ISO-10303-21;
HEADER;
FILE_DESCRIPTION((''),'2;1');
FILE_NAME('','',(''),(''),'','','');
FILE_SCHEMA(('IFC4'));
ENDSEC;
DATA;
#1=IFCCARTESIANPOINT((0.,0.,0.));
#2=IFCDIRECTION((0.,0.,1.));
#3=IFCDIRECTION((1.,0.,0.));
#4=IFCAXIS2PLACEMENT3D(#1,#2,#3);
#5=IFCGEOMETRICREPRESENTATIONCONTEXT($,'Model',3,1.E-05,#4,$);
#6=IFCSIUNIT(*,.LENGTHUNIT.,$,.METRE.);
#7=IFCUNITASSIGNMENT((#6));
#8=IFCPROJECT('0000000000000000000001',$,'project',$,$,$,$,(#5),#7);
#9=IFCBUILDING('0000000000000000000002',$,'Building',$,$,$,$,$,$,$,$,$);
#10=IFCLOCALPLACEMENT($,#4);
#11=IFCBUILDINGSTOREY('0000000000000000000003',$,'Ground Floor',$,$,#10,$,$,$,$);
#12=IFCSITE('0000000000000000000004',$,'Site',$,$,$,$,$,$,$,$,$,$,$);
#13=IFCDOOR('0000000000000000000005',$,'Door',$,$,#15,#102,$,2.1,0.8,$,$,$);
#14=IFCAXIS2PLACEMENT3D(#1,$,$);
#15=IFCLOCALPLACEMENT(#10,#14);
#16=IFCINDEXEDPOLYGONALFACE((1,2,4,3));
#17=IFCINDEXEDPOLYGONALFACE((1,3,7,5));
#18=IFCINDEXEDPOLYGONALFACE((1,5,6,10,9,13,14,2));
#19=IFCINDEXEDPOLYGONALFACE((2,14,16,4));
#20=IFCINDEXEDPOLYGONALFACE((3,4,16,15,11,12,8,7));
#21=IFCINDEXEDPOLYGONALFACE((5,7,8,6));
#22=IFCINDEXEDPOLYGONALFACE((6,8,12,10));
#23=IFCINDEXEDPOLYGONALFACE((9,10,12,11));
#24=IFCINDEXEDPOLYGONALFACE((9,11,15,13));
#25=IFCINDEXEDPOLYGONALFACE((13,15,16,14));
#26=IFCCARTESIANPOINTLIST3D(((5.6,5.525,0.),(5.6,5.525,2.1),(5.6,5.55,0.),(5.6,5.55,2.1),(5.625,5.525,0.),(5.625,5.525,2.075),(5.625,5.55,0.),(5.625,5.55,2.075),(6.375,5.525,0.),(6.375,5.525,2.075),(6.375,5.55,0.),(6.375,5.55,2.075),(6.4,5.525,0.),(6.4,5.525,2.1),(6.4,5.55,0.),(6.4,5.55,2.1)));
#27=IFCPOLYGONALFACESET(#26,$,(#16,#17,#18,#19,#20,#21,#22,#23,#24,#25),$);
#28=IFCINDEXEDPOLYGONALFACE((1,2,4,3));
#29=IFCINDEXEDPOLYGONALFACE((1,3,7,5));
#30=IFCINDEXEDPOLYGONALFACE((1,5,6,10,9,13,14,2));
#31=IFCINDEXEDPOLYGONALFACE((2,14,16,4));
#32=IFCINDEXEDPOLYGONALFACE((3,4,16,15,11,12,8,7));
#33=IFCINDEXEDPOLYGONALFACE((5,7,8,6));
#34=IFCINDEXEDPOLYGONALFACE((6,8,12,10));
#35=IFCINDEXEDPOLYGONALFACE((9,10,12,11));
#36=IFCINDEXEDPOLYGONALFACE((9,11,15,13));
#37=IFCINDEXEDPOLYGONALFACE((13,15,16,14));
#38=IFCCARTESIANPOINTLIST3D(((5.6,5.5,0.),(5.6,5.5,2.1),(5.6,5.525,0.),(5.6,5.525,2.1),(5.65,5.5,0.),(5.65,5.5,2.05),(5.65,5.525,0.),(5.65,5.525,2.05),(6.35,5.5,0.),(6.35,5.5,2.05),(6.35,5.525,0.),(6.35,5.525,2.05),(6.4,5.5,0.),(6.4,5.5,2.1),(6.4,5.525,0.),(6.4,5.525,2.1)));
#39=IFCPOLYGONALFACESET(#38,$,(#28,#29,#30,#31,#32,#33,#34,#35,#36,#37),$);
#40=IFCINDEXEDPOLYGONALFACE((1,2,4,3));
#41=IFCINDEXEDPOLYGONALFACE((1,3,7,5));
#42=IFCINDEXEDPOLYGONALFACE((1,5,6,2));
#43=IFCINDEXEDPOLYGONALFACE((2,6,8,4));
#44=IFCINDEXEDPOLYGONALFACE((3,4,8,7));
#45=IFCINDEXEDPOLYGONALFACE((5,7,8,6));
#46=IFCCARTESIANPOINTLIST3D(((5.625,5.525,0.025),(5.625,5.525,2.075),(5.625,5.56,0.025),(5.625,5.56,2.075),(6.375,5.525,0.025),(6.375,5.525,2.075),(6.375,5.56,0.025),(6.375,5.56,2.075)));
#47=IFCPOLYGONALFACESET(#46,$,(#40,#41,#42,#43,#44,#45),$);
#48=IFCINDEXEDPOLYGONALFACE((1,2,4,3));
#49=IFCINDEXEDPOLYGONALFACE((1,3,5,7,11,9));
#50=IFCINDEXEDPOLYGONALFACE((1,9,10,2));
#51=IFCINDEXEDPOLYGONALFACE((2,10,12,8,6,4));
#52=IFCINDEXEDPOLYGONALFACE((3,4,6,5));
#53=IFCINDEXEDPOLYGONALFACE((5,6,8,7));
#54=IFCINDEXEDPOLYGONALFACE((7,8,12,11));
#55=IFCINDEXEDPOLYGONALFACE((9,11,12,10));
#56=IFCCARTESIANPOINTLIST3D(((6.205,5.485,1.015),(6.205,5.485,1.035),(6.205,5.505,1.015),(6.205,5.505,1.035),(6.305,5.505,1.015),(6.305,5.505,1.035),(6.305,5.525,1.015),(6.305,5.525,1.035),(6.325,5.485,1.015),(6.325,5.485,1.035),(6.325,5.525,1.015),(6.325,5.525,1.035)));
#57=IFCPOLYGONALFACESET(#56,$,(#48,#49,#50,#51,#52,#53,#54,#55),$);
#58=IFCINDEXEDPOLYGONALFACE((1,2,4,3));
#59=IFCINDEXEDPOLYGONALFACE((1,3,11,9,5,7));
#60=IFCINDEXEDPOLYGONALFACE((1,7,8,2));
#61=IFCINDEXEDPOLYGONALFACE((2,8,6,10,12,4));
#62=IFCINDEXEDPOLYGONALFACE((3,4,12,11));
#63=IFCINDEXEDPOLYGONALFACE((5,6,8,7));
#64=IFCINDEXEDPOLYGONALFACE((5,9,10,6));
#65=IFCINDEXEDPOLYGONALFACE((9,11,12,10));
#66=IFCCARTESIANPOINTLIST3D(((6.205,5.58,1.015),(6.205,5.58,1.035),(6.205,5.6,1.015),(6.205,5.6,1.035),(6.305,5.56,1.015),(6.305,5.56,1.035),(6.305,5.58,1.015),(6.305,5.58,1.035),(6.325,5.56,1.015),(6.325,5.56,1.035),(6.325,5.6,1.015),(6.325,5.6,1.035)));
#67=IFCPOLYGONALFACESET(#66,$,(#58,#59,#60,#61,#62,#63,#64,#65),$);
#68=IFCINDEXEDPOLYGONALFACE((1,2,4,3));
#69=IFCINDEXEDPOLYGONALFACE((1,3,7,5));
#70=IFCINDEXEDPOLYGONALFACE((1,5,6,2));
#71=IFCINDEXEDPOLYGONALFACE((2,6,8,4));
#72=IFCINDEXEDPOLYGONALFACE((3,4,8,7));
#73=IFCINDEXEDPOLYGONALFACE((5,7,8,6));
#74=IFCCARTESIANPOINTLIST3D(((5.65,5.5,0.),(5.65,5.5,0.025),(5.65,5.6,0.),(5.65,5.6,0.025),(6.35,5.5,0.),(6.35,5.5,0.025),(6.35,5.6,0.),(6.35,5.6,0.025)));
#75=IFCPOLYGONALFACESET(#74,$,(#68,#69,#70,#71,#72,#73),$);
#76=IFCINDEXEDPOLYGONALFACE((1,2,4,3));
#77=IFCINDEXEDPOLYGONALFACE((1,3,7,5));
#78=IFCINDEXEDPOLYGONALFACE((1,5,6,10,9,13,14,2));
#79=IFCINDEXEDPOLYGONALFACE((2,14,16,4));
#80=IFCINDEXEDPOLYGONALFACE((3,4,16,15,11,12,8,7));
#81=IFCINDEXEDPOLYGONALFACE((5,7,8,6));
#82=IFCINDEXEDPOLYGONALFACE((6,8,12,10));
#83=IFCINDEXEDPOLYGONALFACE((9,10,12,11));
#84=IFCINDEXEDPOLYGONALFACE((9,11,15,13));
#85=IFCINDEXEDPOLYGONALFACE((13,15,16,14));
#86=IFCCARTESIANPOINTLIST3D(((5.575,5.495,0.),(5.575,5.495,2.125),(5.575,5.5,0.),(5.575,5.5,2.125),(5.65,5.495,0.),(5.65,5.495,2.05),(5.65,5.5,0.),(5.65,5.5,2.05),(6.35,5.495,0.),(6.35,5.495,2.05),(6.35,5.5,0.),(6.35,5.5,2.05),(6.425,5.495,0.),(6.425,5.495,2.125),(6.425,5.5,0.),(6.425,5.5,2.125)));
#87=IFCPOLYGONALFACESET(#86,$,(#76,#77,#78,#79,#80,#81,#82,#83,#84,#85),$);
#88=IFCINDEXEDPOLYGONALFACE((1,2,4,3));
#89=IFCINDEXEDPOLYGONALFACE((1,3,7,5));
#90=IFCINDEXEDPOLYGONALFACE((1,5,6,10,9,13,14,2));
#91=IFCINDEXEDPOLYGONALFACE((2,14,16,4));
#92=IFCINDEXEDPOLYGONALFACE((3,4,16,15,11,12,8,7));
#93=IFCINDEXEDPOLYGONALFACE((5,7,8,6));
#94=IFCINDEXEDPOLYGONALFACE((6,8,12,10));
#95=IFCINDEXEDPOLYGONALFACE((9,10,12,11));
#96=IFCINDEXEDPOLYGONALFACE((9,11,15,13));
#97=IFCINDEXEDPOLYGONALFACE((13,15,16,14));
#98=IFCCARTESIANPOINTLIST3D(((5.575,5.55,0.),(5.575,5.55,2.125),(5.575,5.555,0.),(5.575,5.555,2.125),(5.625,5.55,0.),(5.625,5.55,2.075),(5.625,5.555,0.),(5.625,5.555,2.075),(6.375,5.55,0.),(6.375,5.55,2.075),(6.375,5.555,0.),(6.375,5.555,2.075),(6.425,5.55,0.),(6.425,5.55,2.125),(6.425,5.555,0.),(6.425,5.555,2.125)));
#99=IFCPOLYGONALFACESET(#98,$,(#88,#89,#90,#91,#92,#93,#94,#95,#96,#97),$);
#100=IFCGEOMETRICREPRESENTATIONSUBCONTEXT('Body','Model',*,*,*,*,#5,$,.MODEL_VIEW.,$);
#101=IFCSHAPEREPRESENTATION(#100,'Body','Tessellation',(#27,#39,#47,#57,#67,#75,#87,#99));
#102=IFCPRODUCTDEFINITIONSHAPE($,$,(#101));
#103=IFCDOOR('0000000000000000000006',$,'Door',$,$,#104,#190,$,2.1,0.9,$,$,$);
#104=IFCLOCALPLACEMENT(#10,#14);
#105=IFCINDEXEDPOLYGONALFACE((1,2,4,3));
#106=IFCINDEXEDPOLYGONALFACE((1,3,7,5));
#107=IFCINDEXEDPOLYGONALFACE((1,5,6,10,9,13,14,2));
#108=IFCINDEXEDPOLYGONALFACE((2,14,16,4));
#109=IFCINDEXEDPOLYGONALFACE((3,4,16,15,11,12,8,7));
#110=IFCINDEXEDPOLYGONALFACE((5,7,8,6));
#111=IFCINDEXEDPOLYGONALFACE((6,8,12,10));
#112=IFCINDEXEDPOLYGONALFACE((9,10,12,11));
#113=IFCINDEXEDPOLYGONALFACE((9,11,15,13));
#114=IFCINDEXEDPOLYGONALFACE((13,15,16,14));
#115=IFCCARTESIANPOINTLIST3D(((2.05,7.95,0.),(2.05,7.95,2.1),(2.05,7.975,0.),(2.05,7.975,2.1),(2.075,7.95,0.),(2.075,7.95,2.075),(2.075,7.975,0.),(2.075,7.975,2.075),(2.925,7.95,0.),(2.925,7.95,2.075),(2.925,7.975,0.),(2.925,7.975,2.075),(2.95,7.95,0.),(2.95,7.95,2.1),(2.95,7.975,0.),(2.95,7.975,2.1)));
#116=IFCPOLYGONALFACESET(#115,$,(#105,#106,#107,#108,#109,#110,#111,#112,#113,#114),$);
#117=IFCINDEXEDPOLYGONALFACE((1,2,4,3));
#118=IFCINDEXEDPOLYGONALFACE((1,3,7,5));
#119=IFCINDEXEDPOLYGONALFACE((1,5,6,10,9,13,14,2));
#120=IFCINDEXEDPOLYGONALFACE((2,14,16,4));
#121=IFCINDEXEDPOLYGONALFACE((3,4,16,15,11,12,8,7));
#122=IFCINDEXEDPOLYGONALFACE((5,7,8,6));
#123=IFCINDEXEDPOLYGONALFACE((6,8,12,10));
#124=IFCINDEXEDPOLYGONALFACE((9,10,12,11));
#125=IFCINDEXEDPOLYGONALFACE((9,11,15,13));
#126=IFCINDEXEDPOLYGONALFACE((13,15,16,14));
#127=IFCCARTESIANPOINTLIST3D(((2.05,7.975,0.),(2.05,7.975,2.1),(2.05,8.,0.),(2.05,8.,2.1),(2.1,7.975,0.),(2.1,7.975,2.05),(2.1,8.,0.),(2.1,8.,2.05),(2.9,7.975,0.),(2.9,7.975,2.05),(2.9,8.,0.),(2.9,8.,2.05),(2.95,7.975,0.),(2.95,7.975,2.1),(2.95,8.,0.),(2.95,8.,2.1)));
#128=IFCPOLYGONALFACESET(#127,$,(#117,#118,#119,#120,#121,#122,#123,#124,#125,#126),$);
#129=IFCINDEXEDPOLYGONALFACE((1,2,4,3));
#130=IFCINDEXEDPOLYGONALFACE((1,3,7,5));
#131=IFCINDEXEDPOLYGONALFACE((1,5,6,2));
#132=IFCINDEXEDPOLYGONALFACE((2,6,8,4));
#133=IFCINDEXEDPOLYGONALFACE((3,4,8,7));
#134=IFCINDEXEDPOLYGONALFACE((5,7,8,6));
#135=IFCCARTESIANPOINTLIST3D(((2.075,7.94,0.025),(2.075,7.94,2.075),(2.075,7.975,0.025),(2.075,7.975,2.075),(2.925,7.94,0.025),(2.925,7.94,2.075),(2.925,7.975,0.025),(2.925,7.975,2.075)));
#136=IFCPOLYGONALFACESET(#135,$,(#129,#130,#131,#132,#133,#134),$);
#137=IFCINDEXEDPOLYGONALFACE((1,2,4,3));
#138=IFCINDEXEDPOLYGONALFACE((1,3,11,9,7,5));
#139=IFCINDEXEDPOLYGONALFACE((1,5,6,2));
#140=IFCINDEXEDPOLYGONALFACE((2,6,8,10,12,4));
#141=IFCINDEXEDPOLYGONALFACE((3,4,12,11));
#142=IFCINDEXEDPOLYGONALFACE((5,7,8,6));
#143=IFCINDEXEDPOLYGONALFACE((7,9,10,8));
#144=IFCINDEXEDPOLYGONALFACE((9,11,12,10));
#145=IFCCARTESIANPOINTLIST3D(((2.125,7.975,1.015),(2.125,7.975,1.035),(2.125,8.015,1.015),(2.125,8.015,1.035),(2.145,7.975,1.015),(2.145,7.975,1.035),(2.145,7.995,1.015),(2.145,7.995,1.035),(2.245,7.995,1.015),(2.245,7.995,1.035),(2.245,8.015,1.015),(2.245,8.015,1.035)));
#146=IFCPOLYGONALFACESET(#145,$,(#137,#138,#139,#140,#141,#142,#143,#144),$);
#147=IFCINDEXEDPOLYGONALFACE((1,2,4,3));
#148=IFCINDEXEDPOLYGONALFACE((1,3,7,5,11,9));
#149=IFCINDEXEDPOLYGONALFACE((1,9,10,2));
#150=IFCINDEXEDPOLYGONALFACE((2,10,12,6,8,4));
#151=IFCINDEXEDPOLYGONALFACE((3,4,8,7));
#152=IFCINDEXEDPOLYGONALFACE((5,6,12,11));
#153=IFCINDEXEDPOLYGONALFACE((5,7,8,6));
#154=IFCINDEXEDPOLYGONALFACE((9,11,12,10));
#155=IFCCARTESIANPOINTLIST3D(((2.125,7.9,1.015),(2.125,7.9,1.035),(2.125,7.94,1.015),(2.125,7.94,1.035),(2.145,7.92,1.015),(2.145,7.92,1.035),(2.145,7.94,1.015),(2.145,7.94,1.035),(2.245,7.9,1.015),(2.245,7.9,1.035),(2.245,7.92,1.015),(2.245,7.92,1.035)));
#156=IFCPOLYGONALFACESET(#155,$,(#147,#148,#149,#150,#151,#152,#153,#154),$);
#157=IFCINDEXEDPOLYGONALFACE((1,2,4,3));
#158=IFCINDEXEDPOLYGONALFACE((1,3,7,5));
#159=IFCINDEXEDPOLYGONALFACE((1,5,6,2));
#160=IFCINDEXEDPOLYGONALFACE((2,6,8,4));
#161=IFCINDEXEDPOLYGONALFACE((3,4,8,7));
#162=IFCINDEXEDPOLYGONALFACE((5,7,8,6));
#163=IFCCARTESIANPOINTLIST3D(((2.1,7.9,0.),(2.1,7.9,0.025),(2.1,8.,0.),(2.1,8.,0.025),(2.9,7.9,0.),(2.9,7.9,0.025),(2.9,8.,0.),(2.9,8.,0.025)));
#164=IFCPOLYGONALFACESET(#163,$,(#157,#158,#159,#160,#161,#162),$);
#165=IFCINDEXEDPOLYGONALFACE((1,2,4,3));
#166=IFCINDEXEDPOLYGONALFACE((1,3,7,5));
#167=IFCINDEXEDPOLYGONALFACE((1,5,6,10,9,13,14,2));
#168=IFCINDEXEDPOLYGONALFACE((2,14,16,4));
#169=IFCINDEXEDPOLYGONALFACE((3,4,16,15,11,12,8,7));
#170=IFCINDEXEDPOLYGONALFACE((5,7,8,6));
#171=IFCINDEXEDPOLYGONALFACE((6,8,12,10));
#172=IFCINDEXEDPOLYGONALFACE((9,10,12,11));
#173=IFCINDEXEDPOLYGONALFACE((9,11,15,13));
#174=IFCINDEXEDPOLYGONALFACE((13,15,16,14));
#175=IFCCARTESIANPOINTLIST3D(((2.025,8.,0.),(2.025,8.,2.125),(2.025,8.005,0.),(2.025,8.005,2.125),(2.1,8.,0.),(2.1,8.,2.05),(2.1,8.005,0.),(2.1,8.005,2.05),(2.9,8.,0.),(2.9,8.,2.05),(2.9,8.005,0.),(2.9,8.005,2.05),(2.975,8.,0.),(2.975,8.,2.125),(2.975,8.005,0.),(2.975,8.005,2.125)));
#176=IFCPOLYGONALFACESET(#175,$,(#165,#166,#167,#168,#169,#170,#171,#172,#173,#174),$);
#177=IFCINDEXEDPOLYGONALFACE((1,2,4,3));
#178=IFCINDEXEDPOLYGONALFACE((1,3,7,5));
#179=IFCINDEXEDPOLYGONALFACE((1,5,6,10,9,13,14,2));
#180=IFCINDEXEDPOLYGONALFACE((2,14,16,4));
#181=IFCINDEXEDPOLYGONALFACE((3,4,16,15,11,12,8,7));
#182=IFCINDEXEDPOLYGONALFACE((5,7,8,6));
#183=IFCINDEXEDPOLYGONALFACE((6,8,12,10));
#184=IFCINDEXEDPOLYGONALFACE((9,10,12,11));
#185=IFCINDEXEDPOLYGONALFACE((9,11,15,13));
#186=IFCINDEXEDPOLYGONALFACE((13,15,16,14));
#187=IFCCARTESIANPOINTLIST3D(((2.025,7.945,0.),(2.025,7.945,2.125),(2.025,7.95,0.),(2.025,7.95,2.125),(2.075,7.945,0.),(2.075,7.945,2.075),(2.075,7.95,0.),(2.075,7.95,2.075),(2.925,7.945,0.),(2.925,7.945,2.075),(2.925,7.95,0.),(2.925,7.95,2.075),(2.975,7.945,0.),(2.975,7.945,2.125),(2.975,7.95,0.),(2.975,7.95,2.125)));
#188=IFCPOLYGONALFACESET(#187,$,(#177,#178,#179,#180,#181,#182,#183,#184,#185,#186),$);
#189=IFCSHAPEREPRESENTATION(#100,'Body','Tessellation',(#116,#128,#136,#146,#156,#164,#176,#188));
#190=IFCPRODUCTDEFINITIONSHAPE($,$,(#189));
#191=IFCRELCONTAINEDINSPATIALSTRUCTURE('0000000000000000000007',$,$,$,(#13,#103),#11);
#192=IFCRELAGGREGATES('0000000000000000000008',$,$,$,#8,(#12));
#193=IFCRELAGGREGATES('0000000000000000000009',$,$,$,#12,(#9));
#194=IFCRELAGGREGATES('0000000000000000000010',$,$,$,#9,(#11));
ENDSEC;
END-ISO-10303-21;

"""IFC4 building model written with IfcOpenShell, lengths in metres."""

from ifc_helpers import new_model, si_unit, frame, origin_with_axes, place, context, subcontext, project, spatial, line, indexed_curve, outline, extrude, element, save


model = new_model("IFC4")

# Units and contexts
model_context = context("Model", 3, precision=1e-05, world=origin_with_axes())
body_context = subcontext(model_context, "Body", "Model", "MODEL_VIEW")
ifc_project = project(units=[si_unit("LENGTHUNIT", "METRE")], contexts=[model_context])

# Site, building, storey
site = spatial("IfcSite", under=ifc_project, Name="Site")
building = spatial("IfcBuilding", under=site, Name="Building")
storey_placement = place(None, origin_with_axes())
storey = spatial("IfcBuildingStorey", under=building, at=storey_placement, Name="Ground Floor")

# Doors
door_1_placement = place(storey_placement, frame((5.6, 5.5, 0.0), z_axis=(0.0, 0.0, 1.0), x_axis=(1.0, 0.0, 0.0)))
element("IfcDoor", 1, at=door_1_placement, inside=storey, Name="Door", OverallHeight=2.1, OverallWidth=0.8, context=body_context, shape_type="SweptSolid", body=[
    extrude(outline(indexed_curve([(0.0, 0.0), (0.0, 2.1), (0.8, 2.1), (0.8, 0.0), (0.775, 0.0), (0.775, 2.075), (0.025, 2.075), (0.025, 0.0)], segments=[line(1, 2, 3, 4, 5, 6, 7, 8, 1)])), frame((0.0, 0.025, 0.0), z_axis=(0.0, -1.0, 0.0), x_axis=(1.0, 0.0, 0.0)), (0.0, 0.0, -1.0), 0.025),
    extrude(outline(indexed_curve([(0.0, 0.0), (0.0, 2.1), (0.8, 2.1), (0.8, 0.0), (0.75, 0.0), (0.75, 2.05), (0.05, 2.05), (0.05, 0.0)], segments=[line(1, 2, 3, 4, 5, 6, 7, 8, 1)])), frame((0.0, 0.0, 0.0), z_axis=(0.0, -1.0, 0.0), x_axis=(1.0, 0.0, 0.0)), (0.0, 0.0, -1.0), 0.025),
    extrude(outline(indexed_curve([(0.0, 0.0), (0.75, 0.0), (0.75, 0.035), (0.0, 0.035)], segments=[line(1, 2, 3, 4, 1)])), frame((0.025, 0.025, 0.025), z_axis=(0.0, 0.0, 1.0), x_axis=(1.0, 0.0, 0.0)), (0.0, 0.0, 1.0), 2.05),
    extrude(outline(indexed_curve([(0.0, 0.0), (0.0, -0.04), (-0.12, -0.04), (-0.12, -0.02), (-0.02, -0.02), (-0.02, 0.0)], segments=[line(1, 2, 3, 4, 5, 6, 1)])), frame((0.725, 0.025, 1.015), z_axis=(0.0, 0.0, 1.0), x_axis=(1.0, 0.0, 0.0)), (0.0, 0.0, 1.0), 0.02),
    extrude(outline(indexed_curve([(0.0, 0.0), (0.0, 0.04), (-0.12, 0.04), (-0.12, 0.02), (-0.02, 0.02), (-0.02, 0.0)], segments=[line(1, 2, 3, 4, 5, 6, 1)])), frame((0.725, 0.06, 1.015), z_axis=(0.0, 0.0, 1.0), x_axis=(1.0, 0.0, 0.0)), (0.0, 0.0, 1.0), 0.02),
    extrude(outline(indexed_curve([(0.0, 0.0), (0.7, 0.0), (0.7, 0.1), (0.0, 0.1)], segments=[line(1, 2, 3, 4, 1)])), frame((0.05, 0.0, 0.0), z_axis=(0.0, 0.0, 1.0), x_axis=(1.0, 0.0, 0.0)), (0.0, 0.0, 1.0), 0.025),
    extrude(outline(indexed_curve([(0.0, 0.0), (0.0, 2.125), (0.85, 2.125), (0.85, 0.0), (0.775, 0.0), (0.775, 2.05), (0.075, 2.05), (0.075, 0.0)], segments=[line(1, 2, 3, 4, 5, 6, 7, 8, 1)])), frame((-0.025, -0.005, 0.0), z_axis=(0.0, -1.0, 0.0), x_axis=(1.0, 0.0, 0.0)), (0.0, 0.0, -1.0), 0.005),
    extrude(outline(indexed_curve([(0.0, 0.0), (0.0, 2.125), (0.85, 2.125), (0.85, 0.0), (0.8, 0.0), (0.8, 2.075), (0.05, 2.075), (0.05, 0.0)], segments=[line(1, 2, 3, 4, 5, 6, 7, 8, 1)])), frame((-0.025, 0.05, 0.0), z_axis=(0.0, -1.0, 0.0), x_axis=(1.0, 0.0, 0.0)), (0.0, 0.0, -1.0), 0.005),
])
door_2_placement = place(storey_placement, frame((2.95, 8.0, 0.0), z_axis=(0.0, 0.0, 1.0), x_axis=(-1.0, 0.0, 0.0)))
element("IfcDoor", 2, at=door_2_placement, inside=storey, Name="Door", OverallHeight=2.1, OverallWidth=0.9, context=body_context, shape_type="SweptSolid", body=[
    extrude(outline(indexed_curve([(0.0, 0.0), (0.0, 2.1), (0.9, 2.1), (0.9, 0.0), (0.875, 0.0), (0.875, 2.075), (0.025, 2.075), (0.025, 0.0)], segments=[line(1, 2, 3, 4, 5, 6, 7, 8, 1)])), frame((0.0, 0.025, 0.0), z_axis=(0.0, -1.0, 0.0), x_axis=(1.0, 0.0, 0.0)), (0.0, 0.0, -1.0), 0.025),
    extrude(outline(indexed_curve([(0.0, 0.0), (0.0, 2.1), (0.9, 2.1), (0.9, 0.0), (0.85, 0.0), (0.85, 2.05), (0.05, 2.05), (0.05, 0.0)], segments=[line(1, 2, 3, 4, 5, 6, 7, 8, 1)])), frame((0.0, 0.0, 0.0), z_axis=(0.0, -1.0, 0.0), x_axis=(1.0, 0.0, 0.0)), (0.0, 0.0, -1.0), 0.025),
    extrude(outline(indexed_curve([(0.0, 0.0), (0.85, 0.0), (0.85, 0.035), (0.0, 0.035)], segments=[line(1, 2, 3, 4, 1)])), frame((0.025, 0.025, 0.025), z_axis=(0.0, 0.0, 1.0), x_axis=(1.0, 0.0, 0.0)), (0.0, 0.0, 1.0), 2.05),
    extrude(outline(indexed_curve([(0.0, 0.0), (0.0, -0.04), (-0.12, -0.04), (-0.12, -0.02), (-0.02, -0.02), (-0.02, 0.0)], segments=[line(1, 2, 3, 4, 5, 6, 1)])), frame((0.825, 0.025, 1.015), z_axis=(0.0, 0.0, 1.0), x_axis=(1.0, 0.0, 0.0)), (0.0, 0.0, 1.0), 0.02),
    extrude(outline(indexed_curve([(0.0, 0.0), (0.0, 0.04), (-0.12, 0.04), (-0.12, 0.02), (-0.02, 0.02), (-0.02, 0.0)], segments=[line(1, 2, 3, 4, 5, 6, 1)])), frame((0.825, 0.06, 1.015), z_axis=(0.0, 0.0, 1.0), x_axis=(1.0, 0.0, 0.0)), (0.0, 0.0, 1.0), 0.02),
    extrude(outline(indexed_curve([(0.0, 0.0), (0.8, 0.0), (0.8, 0.1), (0.0, 0.1)], segments=[line(1, 2, 3, 4, 1)])), frame((0.05, 0.0, 0.0), z_axis=(0.0, 0.0, 1.0), x_axis=(1.0, 0.0, 0.0)), (0.0, 0.0, 1.0), 0.025),
    extrude(outline(indexed_curve([(0.0, 0.0), (0.0, 2.125), (0.95, 2.125), (0.95, 0.0), (0.875, 0.0), (0.875, 2.05), (0.075, 2.05), (0.075, 0.0)], segments=[line(1, 2, 3, 4, 5, 6, 7, 8, 1)])), frame((-0.025, -0.005, 0.0), z_axis=(0.0, -1.0, 0.0), x_axis=(1.0, 0.0, 0.0)), (0.0, 0.0, -1.0), 0.005),
    extrude(outline(indexed_curve([(0.0, 0.0), (0.0, 2.125), (0.95, 2.125), (0.95, 0.0), (0.9, 0.0), (0.9, 2.075), (0.05, 2.075), (0.05, 0.0)], segments=[line(1, 2, 3, 4, 5, 6, 7, 8, 1)])), frame((-0.025, 0.05, 0.0), z_axis=(0.0, -1.0, 0.0), x_axis=(1.0, 0.0, 0.0)), (0.0, 0.0, -1.0), 0.005),
])

save(model, "model.ifc")
